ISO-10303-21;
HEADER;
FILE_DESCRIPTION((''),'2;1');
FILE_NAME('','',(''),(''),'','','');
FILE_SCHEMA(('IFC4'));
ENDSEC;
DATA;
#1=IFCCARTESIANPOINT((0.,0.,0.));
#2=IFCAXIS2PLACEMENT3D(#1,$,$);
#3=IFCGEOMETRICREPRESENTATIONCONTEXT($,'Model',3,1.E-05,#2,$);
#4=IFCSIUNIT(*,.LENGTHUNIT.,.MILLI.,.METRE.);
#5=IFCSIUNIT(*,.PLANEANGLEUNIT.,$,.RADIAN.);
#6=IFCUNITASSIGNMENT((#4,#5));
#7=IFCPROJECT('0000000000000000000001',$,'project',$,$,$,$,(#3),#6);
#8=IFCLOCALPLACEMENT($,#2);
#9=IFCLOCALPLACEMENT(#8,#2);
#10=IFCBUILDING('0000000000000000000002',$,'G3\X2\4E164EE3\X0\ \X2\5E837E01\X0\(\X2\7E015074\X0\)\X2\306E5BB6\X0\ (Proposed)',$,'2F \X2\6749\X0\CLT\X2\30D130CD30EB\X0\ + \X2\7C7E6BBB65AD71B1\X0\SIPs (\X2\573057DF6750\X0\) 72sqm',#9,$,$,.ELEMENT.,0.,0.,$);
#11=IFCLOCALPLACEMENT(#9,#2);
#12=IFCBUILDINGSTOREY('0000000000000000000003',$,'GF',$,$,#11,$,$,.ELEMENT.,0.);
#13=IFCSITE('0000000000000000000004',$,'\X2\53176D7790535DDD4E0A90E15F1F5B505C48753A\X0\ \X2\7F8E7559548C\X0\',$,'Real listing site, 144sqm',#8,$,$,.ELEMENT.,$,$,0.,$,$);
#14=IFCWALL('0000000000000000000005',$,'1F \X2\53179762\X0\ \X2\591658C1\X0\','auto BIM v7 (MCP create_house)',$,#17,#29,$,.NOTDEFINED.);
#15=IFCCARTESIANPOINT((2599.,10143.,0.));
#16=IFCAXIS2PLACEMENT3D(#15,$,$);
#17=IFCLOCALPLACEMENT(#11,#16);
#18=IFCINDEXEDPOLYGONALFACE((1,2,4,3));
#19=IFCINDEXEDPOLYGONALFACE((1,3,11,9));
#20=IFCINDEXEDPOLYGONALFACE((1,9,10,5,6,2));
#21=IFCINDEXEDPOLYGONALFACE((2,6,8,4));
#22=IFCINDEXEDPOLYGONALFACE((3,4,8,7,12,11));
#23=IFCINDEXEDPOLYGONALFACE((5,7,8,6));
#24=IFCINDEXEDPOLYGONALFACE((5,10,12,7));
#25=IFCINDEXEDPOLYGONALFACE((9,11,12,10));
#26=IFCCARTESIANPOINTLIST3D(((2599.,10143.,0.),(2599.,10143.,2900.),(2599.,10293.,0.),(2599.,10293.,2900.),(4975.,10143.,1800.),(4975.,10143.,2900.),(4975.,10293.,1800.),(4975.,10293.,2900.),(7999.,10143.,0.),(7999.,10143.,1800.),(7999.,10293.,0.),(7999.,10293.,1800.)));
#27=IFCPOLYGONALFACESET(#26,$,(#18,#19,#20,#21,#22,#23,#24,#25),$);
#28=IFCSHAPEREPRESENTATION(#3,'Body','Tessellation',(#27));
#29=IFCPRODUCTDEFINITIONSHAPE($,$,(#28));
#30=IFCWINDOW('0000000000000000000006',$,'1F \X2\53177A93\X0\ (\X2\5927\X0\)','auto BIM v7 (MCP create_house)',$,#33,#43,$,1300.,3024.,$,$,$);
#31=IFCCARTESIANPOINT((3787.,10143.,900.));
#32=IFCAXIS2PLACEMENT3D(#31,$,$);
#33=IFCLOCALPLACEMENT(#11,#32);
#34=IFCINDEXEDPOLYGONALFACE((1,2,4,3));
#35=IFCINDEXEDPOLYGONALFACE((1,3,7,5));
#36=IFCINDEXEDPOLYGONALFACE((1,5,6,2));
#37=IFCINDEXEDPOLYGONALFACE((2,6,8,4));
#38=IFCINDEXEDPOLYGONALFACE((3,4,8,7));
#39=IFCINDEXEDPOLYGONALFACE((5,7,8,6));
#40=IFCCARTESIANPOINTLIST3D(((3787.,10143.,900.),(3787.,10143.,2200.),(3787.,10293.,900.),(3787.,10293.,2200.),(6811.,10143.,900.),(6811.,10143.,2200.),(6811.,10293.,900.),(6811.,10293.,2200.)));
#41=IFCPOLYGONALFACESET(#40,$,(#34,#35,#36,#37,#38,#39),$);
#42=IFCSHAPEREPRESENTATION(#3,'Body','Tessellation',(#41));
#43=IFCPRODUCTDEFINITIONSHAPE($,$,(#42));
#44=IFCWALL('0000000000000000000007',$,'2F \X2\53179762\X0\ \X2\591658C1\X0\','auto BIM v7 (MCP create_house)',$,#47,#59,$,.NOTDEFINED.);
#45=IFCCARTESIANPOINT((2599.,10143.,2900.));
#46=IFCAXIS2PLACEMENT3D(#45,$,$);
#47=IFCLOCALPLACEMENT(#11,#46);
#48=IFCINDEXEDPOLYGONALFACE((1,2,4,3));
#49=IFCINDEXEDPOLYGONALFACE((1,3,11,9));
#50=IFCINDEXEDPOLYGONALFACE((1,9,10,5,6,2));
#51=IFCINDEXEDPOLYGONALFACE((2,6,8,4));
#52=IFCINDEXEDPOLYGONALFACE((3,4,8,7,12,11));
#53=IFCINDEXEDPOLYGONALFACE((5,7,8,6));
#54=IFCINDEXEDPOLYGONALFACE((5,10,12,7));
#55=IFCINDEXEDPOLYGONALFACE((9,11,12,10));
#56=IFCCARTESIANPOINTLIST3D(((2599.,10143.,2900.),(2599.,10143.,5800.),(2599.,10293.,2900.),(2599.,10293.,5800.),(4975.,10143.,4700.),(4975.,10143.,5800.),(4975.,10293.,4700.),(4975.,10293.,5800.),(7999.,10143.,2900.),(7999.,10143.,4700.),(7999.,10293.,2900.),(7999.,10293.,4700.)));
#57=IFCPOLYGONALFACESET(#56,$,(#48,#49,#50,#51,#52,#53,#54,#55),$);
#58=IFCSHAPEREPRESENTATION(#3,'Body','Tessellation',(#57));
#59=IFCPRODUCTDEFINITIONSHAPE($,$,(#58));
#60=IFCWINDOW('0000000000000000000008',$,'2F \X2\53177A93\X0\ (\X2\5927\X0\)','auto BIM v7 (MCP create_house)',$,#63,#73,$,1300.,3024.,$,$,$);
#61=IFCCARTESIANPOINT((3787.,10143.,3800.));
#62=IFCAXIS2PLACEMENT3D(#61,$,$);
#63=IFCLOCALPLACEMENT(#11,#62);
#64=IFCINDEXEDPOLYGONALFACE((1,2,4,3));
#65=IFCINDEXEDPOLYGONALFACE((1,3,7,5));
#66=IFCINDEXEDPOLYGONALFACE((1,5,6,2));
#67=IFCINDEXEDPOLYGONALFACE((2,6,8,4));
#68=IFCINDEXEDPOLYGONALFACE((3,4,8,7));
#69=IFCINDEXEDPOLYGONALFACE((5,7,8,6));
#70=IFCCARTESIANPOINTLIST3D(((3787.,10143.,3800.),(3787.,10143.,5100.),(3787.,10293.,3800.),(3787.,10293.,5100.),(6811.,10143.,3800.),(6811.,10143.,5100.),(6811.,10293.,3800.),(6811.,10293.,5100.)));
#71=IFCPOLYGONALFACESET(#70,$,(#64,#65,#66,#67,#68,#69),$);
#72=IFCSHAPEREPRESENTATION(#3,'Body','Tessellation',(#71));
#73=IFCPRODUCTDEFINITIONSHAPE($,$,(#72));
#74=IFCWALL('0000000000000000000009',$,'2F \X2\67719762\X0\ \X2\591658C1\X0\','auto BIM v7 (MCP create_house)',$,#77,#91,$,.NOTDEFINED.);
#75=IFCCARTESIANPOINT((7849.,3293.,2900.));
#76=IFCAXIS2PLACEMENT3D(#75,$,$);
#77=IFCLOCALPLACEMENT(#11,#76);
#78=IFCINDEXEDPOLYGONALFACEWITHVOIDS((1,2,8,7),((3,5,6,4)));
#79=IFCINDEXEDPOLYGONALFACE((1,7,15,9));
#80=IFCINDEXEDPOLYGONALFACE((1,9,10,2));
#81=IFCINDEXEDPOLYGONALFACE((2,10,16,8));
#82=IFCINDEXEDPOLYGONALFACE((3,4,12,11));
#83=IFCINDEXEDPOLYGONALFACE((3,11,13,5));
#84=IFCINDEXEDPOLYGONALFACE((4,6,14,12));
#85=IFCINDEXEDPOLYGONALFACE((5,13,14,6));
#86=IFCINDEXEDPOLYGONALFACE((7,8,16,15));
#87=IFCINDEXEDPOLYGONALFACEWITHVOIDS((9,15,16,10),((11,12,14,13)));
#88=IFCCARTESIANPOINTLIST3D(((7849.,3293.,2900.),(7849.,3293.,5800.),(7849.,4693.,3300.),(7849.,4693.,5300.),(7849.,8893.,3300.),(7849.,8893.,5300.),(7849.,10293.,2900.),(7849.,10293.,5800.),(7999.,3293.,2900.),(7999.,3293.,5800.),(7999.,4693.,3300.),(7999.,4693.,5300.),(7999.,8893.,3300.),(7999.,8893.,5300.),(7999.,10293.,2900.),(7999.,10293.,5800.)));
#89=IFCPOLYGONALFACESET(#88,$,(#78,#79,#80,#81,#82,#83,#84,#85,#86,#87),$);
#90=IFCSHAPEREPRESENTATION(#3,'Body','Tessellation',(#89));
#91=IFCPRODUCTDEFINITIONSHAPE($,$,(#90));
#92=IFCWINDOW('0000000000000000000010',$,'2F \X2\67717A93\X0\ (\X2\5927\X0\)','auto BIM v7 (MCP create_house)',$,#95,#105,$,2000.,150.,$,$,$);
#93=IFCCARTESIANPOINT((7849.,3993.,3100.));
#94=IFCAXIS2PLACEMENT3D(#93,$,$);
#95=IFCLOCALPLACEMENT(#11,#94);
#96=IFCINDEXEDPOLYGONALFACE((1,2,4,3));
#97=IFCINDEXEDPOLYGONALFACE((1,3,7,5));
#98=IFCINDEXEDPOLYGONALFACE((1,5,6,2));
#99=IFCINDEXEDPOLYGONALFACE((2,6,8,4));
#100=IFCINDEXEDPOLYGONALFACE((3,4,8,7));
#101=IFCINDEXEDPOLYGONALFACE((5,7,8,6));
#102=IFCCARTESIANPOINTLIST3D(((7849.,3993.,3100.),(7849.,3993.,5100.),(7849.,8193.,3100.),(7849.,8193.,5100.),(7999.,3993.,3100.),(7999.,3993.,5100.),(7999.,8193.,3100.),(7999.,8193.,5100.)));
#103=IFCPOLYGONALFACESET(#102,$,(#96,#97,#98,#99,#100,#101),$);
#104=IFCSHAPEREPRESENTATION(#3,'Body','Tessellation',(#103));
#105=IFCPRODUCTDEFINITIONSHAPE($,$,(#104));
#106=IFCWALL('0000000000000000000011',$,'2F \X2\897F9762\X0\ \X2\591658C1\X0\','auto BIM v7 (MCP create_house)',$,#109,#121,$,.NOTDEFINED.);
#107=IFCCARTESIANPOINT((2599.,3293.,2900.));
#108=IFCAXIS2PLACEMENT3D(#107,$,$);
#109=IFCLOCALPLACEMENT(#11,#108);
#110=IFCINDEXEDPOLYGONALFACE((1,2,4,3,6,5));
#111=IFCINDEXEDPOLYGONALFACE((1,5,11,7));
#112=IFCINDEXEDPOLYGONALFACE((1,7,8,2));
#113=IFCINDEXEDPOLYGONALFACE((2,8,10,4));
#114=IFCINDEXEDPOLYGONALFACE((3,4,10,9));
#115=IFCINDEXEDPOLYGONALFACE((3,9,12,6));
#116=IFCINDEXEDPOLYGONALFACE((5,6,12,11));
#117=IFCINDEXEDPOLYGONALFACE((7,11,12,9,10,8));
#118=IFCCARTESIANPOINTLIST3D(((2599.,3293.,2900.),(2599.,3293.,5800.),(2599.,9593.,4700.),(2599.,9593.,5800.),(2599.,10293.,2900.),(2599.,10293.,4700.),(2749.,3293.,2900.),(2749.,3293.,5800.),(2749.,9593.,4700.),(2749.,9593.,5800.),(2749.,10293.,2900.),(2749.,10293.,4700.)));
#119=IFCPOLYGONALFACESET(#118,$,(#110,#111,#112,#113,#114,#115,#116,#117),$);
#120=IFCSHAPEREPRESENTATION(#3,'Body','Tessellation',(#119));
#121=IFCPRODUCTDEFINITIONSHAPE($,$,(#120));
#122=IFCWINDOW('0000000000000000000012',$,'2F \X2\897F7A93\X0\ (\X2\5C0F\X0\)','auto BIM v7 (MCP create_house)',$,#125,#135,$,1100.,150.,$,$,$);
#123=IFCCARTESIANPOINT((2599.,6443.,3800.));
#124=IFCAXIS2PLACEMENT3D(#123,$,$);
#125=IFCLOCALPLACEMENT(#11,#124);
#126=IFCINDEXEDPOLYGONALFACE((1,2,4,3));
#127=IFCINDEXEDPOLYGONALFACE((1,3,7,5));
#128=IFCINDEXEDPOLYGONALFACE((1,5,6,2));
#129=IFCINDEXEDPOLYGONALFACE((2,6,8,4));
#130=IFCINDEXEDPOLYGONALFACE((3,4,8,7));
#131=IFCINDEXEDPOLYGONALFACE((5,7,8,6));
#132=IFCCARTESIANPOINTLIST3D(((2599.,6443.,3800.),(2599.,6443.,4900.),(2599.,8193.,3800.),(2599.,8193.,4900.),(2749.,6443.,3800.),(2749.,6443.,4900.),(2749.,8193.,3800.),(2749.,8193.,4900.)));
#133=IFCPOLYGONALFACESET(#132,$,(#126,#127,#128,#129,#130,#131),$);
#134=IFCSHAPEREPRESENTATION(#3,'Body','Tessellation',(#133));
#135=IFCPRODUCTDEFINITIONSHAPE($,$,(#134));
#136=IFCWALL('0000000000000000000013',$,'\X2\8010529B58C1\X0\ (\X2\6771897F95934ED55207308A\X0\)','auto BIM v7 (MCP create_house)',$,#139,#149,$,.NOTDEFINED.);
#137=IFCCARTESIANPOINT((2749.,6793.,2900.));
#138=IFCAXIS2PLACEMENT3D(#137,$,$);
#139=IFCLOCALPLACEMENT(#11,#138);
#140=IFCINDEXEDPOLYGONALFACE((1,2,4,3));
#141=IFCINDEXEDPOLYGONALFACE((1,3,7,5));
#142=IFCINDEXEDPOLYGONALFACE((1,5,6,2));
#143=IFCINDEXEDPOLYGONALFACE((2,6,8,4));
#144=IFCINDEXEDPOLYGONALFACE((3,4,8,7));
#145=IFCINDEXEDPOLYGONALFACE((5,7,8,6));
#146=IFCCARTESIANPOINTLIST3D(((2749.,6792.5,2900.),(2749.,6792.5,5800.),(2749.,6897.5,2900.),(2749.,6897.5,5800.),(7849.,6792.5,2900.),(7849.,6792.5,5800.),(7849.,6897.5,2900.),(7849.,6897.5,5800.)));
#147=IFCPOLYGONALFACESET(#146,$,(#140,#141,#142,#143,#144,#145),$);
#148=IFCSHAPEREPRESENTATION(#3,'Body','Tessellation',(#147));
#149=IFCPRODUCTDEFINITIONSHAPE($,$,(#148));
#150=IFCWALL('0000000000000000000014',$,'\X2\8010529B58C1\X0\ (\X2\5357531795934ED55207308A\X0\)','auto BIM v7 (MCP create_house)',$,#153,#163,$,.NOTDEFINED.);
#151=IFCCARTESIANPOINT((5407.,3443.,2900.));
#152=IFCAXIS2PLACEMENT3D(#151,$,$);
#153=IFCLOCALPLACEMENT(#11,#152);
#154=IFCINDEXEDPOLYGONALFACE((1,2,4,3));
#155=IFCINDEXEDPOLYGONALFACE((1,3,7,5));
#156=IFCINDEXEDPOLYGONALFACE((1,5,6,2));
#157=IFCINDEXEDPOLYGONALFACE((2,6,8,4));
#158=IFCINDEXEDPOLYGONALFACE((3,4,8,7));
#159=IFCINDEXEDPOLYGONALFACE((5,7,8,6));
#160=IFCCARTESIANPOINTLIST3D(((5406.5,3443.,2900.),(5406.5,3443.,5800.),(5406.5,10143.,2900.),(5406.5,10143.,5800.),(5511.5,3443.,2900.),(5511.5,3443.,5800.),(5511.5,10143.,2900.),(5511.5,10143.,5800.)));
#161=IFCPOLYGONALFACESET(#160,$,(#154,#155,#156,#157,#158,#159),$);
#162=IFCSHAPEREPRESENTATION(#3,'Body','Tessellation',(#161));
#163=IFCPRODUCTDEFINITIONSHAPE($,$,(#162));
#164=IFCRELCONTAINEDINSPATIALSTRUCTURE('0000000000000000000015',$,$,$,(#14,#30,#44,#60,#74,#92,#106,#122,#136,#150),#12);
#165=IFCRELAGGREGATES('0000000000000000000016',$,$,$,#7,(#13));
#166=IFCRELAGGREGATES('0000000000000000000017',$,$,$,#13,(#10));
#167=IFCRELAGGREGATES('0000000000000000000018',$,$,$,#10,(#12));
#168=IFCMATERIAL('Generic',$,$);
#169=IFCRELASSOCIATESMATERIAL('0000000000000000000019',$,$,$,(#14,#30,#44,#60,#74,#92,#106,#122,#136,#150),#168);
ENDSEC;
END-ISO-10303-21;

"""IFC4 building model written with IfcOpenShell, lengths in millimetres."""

from ifc_helpers import new_model, si_unit, frame, frame_2d, origin, place, context, project, spatial, rectangle, extrude, material, element, fill, save


model = new_model("IFC4")

# Units and contexts
model_context = context("Model", 3, precision=1e-05, world=origin())
ifc_project = project(units=[si_unit("LENGTHUNIT", "METRE", prefix="MILLI"), si_unit("PLANEANGLEUNIT", "RADIAN")], contexts=[model_context])

# Site, building, storey
site_placement = place(None, origin())
site = spatial("IfcSite", under=ifc_project, at=site_placement, Name="北海道川上郡弟子屈町 美留和", ObjectType="Real listing site, 144sqm", CompositionType="ELEMENT", RefElevation=0.0)
building_placement = place(site_placement, origin())
building = spatial("IfcBuilding", under=site, at=building_placement, Name="G3世代 広縁(縁側)の家 (Proposed)", ObjectType="2F 杉CLTパネル + 籾殻断熱SIPs (地域材) 72sqm", CompositionType="ELEMENT", ElevationOfRefHeight=0.0, ElevationOfTerrain=0.0)
storey_placement = place(building_placement, origin())
storey = spatial("IfcBuildingStorey", under=building, at=storey_placement, Name="GF", CompositionType="ELEMENT", Elevation=0.0)

# Wall, opening, window
ifc_material = material(Name="Generic")
wall_1_placement = place(storey_placement, frame((2599.0, 10143.0, 0.0)))
wall_1 = element("IfcWall", 1, at=wall_1_placement, inside=storey, material=ifc_material, Name="1F 北面 外壁", Description="auto BIM v7 (MCP create_house)", PredefinedType="NOTDEFINED", context=model_context, shape_type="SweptSolid", body=[
    extrude(rectangle(XDim=5400.0, YDim=150.0, at=frame_2d((2700.0, 75.0))), frame((2599.0, 10143.0, 0.0)), (0.0, 0.0, 1.0), 2900.0),
])
opening_1_placement = place(storey_placement, frame((3787.0, 10143.0, 900.0)))
opening_1 = element("IfcOpeningElement", 2, at=opening_1_placement, cuts=wall_1, PredefinedType="NOTDEFINED", context=model_context, shape_type="SweptSolid", body=[
    extrude(rectangle(XDim=3024.0, YDim=150.0, at=frame_2d((1512.0, 75.0))), frame((3787.0, 10143.0, 900.0)), (0.0, 0.0, 1.0), 1300.0),
])
window_1_placement = place(storey_placement, frame((3787.0, 10143.0, 900.0)))
window_1 = element("IfcWindow", 3, at=window_1_placement, inside=storey, material=ifc_material, Name="1F 北窓 (大)", Description="auto BIM v7 (MCP create_house)", OverallHeight=1300.0, OverallWidth=3024.0, context=model_context, shape_type="SweptSolid", body=[
    extrude(rectangle(XDim=3024.0, YDim=150.0, at=frame_2d((1512.0, 75.0))), frame((3787.0, 10143.0, 900.0)), (0.0, 0.0, 1.0), 1300.0),
])
fill(opening_1, window_1)

# Walls, openings, windows
wall_2_placement = place(storey_placement, frame((2599.0, 10143.0, 2900.0)))
wall_2 = element("IfcWall", 4, at=wall_2_placement, inside=storey, material=ifc_material, Name="2F 北面 外壁", Description="auto BIM v7 (MCP create_house)", PredefinedType="NOTDEFINED", context=model_context, shape_type="SweptSolid", body=[
    extrude(rectangle(XDim=5400.0, YDim=150.0, at=frame_2d((2700.0, 75.0))), frame((2599.0, 10143.0, 2900.0)), (0.0, 0.0, 1.0), 2900.0),
])
opening_2_placement = place(storey_placement, frame((3787.0, 10143.0, 3800.0)))
opening_2 = element("IfcOpeningElement", 5, at=opening_2_placement, cuts=wall_2, PredefinedType="NOTDEFINED", context=model_context, shape_type="SweptSolid", body=[
    extrude(rectangle(XDim=3024.0, YDim=150.0, at=frame_2d((1512.0, 75.0))), frame((3787.0, 10143.0, 3800.0)), (0.0, 0.0, 1.0), 1300.0),
])
window_2_placement = place(storey_placement, frame((3787.0, 10143.0, 3800.0)))
window_2 = element("IfcWindow", 6, at=window_2_placement, inside=storey, material=ifc_material, Name="2F 北窓 (大)", Description="auto BIM v7 (MCP create_house)", OverallHeight=1300.0, OverallWidth=3024.0, context=model_context, shape_type="SweptSolid", body=[
    extrude(rectangle(XDim=3024.0, YDim=150.0, at=frame_2d((1512.0, 75.0))), frame((3787.0, 10143.0, 3800.0)), (0.0, 0.0, 1.0), 1300.0),
])
fill(opening_2, window_2)
wall_3_placement = place(storey_placement, frame((7849.0, 3293.0, 2900.0)))
wall_3 = element("IfcWall", 7, at=wall_3_placement, inside=storey, material=ifc_material, Name="2F 東面 外壁", Description="auto BIM v7 (MCP create_house)", PredefinedType="NOTDEFINED", context=model_context, shape_type="SweptSolid", body=[
    extrude(rectangle(XDim=150.0, YDim=7000.0, at=frame_2d((75.0, 3500.0))), frame((7849.0, 3293.0, 2900.0)), (0.0, 0.0, 1.0), 2900.0),
])
opening_3_placement = place(storey_placement, frame((7849.0, 3993.0, 3100.0)))
opening_3 = element("IfcOpeningElement", 8, at=opening_3_placement, cuts=wall_3, PredefinedType="NOTDEFINED", context=model_context, shape_type="SweptSolid", body=[
    extrude(rectangle(XDim=150.0, YDim=4200.0, at=frame_2d((75.0, 2100.0))), frame((7849.0, 3993.0, 3100.0)), (0.0, 0.0, 1.0), 2000.0),
])
window_3_placement = place(storey_placement, frame((7849.0, 3993.0, 3100.0)))
window_3 = element("IfcWindow", 9, at=window_3_placement, inside=storey, material=ifc_material, Name="2F 東窓 (大)", Description="auto BIM v7 (MCP create_house)", OverallHeight=2000.0, OverallWidth=150.0, context=model_context, shape_type="SweptSolid", body=[
    extrude(rectangle(XDim=150.0, YDim=4200.0, at=frame_2d((75.0, 2100.0))), frame((7849.0, 3993.0, 3100.0)), (0.0, 0.0, 1.0), 2000.0),
])
fill(opening_3, window_3)
wall_4_placement = place(storey_placement, frame((2599.0, 3293.0, 2900.0)))
wall_4 = element("IfcWall", 10, at=wall_4_placement, inside=storey, material=ifc_material, Name="2F 西面 外壁", Description="auto BIM v7 (MCP create_house)", PredefinedType="NOTDEFINED", context=model_context, shape_type="SweptSolid", body=[
    extrude(rectangle(XDim=150.0, YDim=7000.0, at=frame_2d((75.0, 3500.0))), frame((2599.0, 3293.0, 2900.0)), (0.0, 0.0, 1.0), 2900.0),
])
opening_4_placement = place(storey_placement, frame((2599.0, 6443.0, 3800.0)))
opening_4 = element("IfcOpeningElement", 11, at=opening_4_placement, cuts=wall_4, PredefinedType="NOTDEFINED", context=model_context, shape_type="SweptSolid", body=[
    extrude(rectangle(XDim=150.0, YDim=1750.0, at=frame_2d((75.0, 875.0))), frame((2599.0, 6443.0, 3800.0)), (0.0, 0.0, 1.0), 1100.0),
])
window_4_placement = place(storey_placement, frame((2599.0, 6443.0, 3800.0)))
window_4 = element("IfcWindow", 12, at=window_4_placement, inside=storey, material=ifc_material, Name="2F 西窓 (小)", Description="auto BIM v7 (MCP create_house)", OverallHeight=1100.0, OverallWidth=150.0, context=model_context, shape_type="SweptSolid", body=[
    extrude(rectangle(XDim=150.0, YDim=1750.0, at=frame_2d((75.0, 875.0))), frame((2599.0, 6443.0, 3800.0)), (0.0, 0.0, 1.0), 1100.0),
])
fill(opening_4, window_4)

# Walls
wall_5_placement = place(storey_placement, frame((2749.0, 6793.0, 2900.0)))
element("IfcWall", 13, at=wall_5_placement, inside=storey, material=ifc_material, Name="耐力壁 (東西間仕切り)", Description="auto BIM v7 (MCP create_house)", PredefinedType="NOTDEFINED", context=model_context, shape_type="SweptSolid", body=[
    extrude(rectangle(XDim=5100.0, YDim=105.0, at=frame_2d((2550.0, 52.0))), frame((2749.0, 6793.0, 2900.0)), (0.0, 0.0, 1.0), 2900.0),
])
wall_6_placement = place(storey_placement, frame((5407.0, 3443.0, 2900.0)))
element("IfcWall", 14, at=wall_6_placement, inside=storey, material=ifc_material, Name="耐力壁 (南北間仕切り)", Description="auto BIM v7 (MCP create_house)", PredefinedType="NOTDEFINED", context=model_context, shape_type="SweptSolid", body=[
    extrude(rectangle(XDim=105.0, YDim=6700.0, at=frame_2d((52.0, 3350.0))), frame((5407.0, 3443.0, 2900.0)), (0.0, 0.0, 1.0), 2900.0),
])

save(model, "model.ifc")
